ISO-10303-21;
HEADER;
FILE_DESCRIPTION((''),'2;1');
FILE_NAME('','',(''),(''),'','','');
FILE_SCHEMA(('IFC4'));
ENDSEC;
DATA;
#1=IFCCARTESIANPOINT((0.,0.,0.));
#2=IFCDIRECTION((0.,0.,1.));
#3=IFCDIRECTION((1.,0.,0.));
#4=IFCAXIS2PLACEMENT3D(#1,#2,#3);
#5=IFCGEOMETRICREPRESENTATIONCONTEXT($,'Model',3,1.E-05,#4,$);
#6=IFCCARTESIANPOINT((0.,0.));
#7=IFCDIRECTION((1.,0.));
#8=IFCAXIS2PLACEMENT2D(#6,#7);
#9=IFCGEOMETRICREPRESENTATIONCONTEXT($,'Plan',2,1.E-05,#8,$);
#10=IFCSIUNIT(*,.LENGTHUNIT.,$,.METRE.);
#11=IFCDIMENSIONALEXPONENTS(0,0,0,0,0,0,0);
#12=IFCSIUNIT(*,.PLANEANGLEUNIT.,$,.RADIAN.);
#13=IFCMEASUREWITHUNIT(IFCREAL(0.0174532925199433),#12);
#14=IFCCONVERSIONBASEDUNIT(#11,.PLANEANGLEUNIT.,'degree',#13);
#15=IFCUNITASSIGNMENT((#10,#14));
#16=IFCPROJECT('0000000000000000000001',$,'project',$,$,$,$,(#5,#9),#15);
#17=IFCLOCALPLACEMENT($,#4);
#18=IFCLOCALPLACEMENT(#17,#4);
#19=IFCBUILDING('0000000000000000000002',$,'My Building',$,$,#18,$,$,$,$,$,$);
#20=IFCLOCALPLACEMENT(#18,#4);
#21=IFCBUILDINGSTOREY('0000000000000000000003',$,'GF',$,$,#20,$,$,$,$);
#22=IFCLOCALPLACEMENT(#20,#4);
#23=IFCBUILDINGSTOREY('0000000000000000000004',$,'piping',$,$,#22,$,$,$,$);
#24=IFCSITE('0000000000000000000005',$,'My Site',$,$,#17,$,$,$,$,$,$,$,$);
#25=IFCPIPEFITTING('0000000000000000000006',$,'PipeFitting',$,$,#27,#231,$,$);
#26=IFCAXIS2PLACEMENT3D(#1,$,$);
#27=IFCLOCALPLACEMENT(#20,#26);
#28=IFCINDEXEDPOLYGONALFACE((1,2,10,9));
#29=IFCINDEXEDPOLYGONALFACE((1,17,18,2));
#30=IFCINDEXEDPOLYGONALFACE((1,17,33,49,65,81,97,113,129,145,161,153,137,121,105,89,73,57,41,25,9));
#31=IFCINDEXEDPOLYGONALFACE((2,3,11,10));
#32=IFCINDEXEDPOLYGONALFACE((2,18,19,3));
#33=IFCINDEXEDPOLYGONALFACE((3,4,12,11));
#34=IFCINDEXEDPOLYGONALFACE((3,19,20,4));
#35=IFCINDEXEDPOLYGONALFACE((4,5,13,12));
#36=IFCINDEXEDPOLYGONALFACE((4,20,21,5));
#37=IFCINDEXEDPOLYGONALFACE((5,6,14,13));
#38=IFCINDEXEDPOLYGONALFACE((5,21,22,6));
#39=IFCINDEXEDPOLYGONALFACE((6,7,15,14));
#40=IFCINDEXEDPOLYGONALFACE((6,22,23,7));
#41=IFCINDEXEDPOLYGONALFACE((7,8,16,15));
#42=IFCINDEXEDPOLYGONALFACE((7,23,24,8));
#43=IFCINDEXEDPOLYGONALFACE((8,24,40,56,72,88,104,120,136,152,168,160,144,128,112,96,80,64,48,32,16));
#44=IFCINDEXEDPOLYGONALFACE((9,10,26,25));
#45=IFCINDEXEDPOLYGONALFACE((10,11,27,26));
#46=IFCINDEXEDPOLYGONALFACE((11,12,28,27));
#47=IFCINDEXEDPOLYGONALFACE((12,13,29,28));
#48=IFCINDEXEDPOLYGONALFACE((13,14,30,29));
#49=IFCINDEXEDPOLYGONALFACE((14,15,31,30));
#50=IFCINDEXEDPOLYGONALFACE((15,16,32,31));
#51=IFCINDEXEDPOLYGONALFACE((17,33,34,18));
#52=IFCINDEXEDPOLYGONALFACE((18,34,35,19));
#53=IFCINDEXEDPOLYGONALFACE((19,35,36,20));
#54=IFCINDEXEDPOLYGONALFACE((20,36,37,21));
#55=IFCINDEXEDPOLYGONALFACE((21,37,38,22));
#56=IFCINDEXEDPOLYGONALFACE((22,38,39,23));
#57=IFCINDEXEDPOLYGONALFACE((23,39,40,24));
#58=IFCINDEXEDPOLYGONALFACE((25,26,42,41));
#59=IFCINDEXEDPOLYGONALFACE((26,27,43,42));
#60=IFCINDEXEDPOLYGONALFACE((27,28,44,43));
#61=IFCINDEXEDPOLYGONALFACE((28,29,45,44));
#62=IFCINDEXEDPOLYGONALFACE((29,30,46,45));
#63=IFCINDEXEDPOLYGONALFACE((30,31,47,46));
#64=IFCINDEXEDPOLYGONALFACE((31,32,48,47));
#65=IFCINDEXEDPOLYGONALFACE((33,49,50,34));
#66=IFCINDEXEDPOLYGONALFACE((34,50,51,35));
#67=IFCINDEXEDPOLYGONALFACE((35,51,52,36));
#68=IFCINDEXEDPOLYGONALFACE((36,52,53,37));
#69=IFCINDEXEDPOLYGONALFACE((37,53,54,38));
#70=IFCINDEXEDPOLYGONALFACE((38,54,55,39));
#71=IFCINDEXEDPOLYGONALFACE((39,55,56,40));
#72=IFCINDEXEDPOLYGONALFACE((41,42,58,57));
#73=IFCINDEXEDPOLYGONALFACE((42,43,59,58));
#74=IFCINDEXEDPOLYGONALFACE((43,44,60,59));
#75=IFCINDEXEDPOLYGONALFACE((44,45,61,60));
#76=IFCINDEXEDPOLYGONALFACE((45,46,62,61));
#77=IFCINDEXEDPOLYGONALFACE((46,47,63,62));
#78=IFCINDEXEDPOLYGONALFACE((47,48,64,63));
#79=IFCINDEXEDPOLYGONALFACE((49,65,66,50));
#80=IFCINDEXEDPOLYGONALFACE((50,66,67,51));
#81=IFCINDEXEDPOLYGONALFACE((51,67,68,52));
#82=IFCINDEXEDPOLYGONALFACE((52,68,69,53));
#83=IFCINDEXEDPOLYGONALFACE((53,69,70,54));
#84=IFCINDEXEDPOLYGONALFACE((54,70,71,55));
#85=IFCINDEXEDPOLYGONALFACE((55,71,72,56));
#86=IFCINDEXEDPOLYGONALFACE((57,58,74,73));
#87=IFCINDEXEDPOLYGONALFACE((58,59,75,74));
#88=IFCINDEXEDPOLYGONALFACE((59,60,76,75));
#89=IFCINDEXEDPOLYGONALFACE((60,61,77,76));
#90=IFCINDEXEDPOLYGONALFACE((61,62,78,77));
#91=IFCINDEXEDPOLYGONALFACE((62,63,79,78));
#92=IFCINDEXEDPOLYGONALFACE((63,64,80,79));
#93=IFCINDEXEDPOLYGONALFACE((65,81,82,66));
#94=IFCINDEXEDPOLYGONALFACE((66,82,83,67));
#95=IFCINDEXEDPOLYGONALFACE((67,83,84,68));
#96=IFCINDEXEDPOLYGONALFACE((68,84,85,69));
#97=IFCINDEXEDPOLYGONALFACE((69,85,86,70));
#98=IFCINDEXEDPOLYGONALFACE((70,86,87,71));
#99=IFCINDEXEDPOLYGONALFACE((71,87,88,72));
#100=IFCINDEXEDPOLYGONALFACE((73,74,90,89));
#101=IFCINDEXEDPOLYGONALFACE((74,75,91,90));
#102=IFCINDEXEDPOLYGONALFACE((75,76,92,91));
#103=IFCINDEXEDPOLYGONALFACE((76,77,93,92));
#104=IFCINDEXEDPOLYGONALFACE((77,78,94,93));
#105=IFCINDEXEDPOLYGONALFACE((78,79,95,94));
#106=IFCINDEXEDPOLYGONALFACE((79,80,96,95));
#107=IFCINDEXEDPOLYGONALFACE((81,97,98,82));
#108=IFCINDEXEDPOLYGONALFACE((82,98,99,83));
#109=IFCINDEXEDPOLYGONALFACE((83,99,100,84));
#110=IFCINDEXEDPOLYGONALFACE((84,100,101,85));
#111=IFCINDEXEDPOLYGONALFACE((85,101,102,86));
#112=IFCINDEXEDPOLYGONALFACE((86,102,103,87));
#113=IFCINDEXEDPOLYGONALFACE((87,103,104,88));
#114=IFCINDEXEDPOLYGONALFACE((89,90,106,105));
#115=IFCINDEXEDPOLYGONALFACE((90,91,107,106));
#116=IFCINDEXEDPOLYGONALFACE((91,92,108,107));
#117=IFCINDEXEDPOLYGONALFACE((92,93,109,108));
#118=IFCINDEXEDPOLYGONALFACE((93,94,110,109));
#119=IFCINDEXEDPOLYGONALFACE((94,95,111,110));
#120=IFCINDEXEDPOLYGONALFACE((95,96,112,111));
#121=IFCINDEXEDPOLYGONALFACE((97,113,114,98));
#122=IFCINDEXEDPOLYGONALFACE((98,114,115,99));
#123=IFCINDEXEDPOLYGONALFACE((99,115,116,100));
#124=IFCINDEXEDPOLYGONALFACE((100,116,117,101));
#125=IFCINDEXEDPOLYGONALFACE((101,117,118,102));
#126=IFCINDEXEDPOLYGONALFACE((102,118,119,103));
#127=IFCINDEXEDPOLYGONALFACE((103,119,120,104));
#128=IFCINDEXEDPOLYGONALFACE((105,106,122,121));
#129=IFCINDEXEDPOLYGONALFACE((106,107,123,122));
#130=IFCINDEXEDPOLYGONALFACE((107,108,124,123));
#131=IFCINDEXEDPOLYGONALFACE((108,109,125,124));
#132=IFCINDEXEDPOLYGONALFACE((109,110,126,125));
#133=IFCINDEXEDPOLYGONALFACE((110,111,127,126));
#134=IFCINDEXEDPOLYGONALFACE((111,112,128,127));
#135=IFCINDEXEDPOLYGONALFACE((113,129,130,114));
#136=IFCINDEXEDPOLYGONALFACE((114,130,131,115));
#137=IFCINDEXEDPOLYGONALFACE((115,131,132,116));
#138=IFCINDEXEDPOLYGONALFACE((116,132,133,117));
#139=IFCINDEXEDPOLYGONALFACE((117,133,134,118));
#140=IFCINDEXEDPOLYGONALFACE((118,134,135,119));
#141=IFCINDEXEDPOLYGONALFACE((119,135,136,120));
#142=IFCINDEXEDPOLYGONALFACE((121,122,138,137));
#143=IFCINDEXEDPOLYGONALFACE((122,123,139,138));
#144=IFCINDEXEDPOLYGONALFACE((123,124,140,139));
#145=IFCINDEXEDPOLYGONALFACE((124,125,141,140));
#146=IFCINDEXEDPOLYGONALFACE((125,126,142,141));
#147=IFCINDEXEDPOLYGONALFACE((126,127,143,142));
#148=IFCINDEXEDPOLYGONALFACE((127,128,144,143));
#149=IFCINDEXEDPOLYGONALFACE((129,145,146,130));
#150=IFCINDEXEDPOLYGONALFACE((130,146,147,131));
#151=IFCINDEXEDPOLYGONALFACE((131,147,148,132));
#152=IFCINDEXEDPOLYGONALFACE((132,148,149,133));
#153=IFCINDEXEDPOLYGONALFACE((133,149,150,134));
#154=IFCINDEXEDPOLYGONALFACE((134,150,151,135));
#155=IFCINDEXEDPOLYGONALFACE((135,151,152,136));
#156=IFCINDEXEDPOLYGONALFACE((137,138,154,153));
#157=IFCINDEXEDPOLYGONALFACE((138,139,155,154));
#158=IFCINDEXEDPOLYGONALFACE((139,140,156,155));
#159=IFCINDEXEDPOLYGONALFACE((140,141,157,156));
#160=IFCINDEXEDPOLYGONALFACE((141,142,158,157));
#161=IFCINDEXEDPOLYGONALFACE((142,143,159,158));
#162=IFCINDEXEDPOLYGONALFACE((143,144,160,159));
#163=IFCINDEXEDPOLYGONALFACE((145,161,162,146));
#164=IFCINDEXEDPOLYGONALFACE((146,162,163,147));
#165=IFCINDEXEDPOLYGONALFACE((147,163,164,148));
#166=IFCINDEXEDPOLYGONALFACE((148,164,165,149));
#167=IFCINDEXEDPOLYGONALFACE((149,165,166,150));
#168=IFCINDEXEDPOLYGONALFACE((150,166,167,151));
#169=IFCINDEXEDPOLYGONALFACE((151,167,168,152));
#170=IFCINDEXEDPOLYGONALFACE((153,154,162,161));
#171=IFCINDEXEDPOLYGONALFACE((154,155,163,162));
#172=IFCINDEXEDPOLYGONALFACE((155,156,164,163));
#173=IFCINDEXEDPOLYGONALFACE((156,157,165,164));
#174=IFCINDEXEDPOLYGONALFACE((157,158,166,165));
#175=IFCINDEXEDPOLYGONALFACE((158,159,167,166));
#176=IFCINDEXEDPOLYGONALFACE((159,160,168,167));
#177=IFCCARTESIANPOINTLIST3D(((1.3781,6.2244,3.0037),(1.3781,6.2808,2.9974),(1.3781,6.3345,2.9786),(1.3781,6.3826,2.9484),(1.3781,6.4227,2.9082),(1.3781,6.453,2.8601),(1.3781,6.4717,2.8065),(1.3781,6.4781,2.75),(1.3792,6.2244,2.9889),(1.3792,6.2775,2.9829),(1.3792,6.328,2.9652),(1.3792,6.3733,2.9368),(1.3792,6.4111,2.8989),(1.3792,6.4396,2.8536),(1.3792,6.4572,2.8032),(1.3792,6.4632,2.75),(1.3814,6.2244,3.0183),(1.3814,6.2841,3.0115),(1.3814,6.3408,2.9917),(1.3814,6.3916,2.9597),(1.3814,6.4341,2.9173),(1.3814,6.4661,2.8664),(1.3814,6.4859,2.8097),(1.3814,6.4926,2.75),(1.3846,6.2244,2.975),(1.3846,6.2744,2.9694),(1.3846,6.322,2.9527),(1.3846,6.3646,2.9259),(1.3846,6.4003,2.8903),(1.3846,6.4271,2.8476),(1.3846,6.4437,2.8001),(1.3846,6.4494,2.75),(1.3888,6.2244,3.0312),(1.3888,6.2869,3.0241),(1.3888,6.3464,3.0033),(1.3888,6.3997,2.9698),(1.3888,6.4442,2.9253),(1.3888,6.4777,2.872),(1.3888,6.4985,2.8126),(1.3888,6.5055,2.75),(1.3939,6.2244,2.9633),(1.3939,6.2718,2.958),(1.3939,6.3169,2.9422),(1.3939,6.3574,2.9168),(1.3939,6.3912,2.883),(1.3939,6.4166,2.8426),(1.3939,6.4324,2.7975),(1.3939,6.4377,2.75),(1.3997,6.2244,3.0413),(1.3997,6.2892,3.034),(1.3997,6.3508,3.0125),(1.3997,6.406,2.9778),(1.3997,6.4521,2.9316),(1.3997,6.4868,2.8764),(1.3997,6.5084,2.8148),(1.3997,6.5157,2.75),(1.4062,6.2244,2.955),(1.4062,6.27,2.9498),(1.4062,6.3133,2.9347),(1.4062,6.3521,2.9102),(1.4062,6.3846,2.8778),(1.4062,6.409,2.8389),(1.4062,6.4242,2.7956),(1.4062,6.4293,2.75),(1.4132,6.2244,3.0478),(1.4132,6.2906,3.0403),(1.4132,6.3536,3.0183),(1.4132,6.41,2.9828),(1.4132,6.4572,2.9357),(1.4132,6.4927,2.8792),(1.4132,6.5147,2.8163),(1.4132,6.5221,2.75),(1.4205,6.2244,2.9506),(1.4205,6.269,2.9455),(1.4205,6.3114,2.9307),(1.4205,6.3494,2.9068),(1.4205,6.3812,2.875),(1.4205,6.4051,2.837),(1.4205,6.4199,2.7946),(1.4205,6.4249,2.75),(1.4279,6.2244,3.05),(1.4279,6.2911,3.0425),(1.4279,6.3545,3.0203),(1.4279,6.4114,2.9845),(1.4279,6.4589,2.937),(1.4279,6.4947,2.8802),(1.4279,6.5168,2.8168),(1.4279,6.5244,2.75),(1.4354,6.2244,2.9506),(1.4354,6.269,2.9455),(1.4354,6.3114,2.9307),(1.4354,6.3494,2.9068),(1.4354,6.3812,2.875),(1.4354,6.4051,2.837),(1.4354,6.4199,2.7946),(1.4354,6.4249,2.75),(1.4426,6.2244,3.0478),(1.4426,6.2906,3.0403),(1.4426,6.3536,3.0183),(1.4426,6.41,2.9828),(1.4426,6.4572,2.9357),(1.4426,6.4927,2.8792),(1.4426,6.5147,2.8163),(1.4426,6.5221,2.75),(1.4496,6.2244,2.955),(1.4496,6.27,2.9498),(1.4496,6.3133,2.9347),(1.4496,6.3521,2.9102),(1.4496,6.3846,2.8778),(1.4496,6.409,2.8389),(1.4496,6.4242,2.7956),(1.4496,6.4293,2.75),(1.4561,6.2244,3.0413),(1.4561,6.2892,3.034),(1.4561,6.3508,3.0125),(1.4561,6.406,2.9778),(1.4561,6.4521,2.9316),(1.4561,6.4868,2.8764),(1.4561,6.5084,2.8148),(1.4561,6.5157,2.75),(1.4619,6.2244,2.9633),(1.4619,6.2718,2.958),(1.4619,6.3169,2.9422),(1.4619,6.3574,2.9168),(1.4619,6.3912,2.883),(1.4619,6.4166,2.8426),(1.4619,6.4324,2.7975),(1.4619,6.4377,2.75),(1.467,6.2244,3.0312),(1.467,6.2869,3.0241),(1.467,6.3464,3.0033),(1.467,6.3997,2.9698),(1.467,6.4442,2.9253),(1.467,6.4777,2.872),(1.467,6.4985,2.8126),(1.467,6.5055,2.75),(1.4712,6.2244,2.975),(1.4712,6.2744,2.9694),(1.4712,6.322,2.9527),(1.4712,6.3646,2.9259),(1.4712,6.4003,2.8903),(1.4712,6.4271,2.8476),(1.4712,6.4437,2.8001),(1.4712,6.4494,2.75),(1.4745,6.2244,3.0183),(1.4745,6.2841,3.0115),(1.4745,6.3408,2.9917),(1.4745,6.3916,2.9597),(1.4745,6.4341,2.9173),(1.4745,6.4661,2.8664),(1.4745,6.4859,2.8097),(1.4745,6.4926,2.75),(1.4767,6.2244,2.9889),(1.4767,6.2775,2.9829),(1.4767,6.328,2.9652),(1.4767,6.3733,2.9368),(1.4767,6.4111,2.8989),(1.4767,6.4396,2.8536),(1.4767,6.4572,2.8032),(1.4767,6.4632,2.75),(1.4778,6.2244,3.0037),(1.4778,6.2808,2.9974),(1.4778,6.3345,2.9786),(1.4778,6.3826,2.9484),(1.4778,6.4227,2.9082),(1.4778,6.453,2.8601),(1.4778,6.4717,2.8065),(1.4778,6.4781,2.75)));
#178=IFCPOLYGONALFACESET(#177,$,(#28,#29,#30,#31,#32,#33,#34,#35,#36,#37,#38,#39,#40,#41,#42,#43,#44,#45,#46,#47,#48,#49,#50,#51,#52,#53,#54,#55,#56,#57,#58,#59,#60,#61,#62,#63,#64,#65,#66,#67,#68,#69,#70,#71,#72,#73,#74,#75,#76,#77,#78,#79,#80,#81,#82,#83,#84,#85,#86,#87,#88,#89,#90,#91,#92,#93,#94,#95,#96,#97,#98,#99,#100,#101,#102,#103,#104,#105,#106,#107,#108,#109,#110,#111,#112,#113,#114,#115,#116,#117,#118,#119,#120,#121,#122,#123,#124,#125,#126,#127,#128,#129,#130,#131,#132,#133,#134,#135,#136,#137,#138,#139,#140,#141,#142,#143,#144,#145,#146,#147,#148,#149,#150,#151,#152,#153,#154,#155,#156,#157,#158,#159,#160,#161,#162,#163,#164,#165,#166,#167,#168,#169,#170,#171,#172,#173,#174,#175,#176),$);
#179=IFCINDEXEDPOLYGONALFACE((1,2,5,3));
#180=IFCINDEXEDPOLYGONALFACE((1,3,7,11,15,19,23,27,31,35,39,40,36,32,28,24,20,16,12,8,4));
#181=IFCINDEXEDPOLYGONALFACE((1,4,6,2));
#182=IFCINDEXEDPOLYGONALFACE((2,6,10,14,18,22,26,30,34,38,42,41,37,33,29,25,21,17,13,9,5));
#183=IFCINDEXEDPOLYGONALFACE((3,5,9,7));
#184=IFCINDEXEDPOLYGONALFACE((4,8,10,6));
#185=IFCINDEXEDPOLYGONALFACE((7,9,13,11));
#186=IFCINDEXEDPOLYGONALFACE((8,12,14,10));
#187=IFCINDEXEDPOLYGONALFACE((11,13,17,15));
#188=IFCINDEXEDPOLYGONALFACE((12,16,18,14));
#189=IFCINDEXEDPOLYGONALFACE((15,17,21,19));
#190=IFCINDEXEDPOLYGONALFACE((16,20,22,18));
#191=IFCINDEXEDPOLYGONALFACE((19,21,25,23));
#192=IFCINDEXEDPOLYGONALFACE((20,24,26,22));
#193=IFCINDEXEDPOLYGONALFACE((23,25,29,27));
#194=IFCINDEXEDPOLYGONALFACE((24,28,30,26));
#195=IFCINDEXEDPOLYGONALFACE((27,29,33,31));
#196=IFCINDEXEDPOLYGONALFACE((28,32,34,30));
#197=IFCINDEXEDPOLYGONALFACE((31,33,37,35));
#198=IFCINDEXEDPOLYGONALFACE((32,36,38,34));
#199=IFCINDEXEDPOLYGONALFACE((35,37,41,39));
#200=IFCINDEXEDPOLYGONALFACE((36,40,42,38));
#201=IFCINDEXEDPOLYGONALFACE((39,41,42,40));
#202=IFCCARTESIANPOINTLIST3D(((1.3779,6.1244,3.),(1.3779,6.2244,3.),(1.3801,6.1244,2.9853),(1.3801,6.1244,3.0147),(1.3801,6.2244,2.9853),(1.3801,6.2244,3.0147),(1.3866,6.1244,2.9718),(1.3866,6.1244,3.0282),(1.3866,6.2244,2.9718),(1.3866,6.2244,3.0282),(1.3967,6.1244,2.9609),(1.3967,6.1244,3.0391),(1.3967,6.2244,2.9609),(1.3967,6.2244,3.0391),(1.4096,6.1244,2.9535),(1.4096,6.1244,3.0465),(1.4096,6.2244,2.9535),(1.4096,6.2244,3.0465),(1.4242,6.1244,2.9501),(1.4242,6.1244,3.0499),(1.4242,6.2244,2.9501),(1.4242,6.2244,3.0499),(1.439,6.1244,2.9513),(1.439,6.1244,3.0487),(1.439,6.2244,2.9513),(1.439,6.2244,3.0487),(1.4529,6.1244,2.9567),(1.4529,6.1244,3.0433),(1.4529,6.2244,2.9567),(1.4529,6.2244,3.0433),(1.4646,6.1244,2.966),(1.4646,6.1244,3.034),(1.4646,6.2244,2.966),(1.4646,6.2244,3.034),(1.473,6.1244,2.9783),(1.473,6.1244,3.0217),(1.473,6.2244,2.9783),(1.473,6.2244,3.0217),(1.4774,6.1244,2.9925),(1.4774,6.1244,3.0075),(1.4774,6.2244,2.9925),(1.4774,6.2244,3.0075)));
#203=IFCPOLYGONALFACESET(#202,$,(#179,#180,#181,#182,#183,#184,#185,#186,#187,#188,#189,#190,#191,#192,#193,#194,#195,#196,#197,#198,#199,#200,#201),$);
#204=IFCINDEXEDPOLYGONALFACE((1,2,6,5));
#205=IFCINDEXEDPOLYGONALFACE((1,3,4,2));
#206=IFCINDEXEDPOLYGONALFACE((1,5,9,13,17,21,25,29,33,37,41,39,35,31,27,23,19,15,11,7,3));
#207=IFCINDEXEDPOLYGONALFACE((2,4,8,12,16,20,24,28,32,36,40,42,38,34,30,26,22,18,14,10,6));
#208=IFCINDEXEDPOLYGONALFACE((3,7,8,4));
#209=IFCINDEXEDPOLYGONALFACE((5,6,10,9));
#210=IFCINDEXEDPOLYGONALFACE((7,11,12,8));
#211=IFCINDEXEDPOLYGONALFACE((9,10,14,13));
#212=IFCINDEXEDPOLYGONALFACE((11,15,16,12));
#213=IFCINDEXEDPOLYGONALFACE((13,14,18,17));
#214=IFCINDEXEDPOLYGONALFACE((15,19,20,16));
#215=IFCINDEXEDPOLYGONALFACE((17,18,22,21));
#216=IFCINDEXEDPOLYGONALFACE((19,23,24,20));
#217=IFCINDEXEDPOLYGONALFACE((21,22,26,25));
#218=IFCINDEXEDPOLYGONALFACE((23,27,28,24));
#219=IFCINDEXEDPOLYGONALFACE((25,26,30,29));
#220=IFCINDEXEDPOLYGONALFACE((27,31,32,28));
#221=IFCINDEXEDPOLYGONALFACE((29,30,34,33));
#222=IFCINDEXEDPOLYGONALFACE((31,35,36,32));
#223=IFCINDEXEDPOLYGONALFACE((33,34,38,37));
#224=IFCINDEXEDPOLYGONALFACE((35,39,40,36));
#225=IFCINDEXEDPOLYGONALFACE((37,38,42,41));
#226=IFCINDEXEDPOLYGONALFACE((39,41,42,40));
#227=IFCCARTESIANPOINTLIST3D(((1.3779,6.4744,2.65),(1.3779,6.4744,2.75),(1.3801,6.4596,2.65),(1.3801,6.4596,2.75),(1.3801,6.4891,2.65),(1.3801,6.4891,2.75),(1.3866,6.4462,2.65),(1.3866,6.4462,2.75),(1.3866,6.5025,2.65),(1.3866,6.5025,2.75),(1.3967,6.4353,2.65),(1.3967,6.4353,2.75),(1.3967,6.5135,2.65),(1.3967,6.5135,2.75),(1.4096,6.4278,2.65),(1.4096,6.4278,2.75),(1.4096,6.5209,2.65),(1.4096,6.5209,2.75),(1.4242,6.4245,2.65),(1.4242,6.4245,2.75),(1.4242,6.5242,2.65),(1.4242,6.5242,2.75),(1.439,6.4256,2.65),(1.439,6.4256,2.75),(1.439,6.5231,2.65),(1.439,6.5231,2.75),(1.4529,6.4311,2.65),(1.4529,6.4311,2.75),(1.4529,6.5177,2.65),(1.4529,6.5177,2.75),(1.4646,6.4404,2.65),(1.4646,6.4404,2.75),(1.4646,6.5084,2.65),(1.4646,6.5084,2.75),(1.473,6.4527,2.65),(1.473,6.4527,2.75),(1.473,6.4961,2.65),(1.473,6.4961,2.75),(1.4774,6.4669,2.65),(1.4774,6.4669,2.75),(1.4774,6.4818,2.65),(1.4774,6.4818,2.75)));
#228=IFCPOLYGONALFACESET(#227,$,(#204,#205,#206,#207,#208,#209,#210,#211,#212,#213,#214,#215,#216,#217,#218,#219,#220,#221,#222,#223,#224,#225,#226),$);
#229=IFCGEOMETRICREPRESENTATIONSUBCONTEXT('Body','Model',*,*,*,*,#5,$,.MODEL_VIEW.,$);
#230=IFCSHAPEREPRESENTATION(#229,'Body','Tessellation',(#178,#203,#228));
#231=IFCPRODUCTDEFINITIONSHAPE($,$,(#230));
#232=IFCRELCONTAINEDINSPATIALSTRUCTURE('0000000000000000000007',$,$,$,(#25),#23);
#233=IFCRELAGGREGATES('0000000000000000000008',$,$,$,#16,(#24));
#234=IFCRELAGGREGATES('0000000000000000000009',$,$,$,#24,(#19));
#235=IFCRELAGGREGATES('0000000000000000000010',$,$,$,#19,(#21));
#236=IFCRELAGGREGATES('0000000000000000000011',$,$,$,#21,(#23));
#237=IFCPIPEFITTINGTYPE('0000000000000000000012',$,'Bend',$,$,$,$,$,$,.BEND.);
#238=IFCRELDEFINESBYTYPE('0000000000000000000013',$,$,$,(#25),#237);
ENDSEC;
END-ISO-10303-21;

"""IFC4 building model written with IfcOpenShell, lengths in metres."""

from ifc_helpers import new_model, entity, si_unit, converted_unit, frame, origin_with_axes, origin_2d_with_axis, place, context, subcontext, project, spatial, circle, extrude, source, transform, mapped, type_object, type_shapes, element, save


model = new_model("IFC4")

# Units and contexts
model_context = context("Model", 3, precision=1e-05, world=origin_with_axes())
plan_context = context("Plan", 2, precision=1e-05, world=origin_2d_with_axis())
body_context = subcontext(model_context, "Body", "Model", "MODEL_VIEW")
ifc_project = project(units=[si_unit("LENGTHUNIT", "METRE"), converted_unit("PLANEANGLEUNIT", "degree", entity("IfcReal", 0.0174532925199433), si_unit("PLANEANGLEUNIT", "RADIAN"), dimensions=[0, 0, 0, 0, 0, 0, 0])], contexts=[model_context, plan_context])

# Site, building, storeys
site_placement = place(None, origin_with_axes())
site = spatial("IfcSite", under=ifc_project, at=site_placement, Name="My Site")
building_placement = place(site_placement, origin_with_axes())
building = spatial("IfcBuilding", under=site, at=building_placement, Name="My Building")
storey_1_placement = place(building_placement, origin_with_axes())
storey_1 = spatial("IfcBuildingStorey", under=building, at=storey_1_placement, Name="GF")
storey_2_placement = place(storey_1_placement, origin_with_axes())
storey_2 = spatial("IfcBuildingStorey", under=storey_1, at=storey_2_placement, Name="piping")

# Pipe fitting
pipe_fitting_type = type_object("IfcPipeFittingType", Name="Bend", PredefinedType="BEND")
shared_shape = source(origin_with_axes(), body_context, "Body", "SolidModel", [
    entity("IfcSweptDiskSolid", entity("IfcIndexedPolyCurve", entity("IfcCartesianPointList3D", [[0.0, 0.0, 0.1], [0.0, -0.0732, 0.2768], [0.0, -0.25, 0.35]]), [entity("IfcArcIndex", [1, 2, 3])]), 0.05),
    extrude(circle(Radius=0.05), origin_with_axes(), (0.0, 0.0, 1.0), 0.1),
    extrude(circle(Radius=0.05), frame((0.0, -0.25, 0.35), z_axis=(0.0, -1.0, 0.0), x_axis=(1.0, 0.0, 0.0)), (0.0, 0.0, 1.0), 0.1),
])
type_shapes(pipe_fitting_type, [shared_shape])
for number, where, z_axis, x_axis, name in (
    (1, (1.4279, 6.1244, 3.0), (0.0, 1.0, 0.0), (-1.0, 0.0, 0.0), "PipeFitting"),
):
    element("IfcPipeFitting", number, at=place(storey_2_placement, frame(where, z_axis=z_axis, x_axis=x_axis)), inside=storey_2, type_object=pipe_fitting_type, Name=name, context=body_context, shape_type="MappedRepresentation", body=[
        mapped(shared_shape, transform((0.0, 0.0, 0.0), x_axis=(1.0, 0.0, 0.0), y_axis=(0.0, 1.0, 0.0), z_axis=(0.0, 0.0, 1.0), scale=1.0)),
    ])

save(model, "model.ifc")
